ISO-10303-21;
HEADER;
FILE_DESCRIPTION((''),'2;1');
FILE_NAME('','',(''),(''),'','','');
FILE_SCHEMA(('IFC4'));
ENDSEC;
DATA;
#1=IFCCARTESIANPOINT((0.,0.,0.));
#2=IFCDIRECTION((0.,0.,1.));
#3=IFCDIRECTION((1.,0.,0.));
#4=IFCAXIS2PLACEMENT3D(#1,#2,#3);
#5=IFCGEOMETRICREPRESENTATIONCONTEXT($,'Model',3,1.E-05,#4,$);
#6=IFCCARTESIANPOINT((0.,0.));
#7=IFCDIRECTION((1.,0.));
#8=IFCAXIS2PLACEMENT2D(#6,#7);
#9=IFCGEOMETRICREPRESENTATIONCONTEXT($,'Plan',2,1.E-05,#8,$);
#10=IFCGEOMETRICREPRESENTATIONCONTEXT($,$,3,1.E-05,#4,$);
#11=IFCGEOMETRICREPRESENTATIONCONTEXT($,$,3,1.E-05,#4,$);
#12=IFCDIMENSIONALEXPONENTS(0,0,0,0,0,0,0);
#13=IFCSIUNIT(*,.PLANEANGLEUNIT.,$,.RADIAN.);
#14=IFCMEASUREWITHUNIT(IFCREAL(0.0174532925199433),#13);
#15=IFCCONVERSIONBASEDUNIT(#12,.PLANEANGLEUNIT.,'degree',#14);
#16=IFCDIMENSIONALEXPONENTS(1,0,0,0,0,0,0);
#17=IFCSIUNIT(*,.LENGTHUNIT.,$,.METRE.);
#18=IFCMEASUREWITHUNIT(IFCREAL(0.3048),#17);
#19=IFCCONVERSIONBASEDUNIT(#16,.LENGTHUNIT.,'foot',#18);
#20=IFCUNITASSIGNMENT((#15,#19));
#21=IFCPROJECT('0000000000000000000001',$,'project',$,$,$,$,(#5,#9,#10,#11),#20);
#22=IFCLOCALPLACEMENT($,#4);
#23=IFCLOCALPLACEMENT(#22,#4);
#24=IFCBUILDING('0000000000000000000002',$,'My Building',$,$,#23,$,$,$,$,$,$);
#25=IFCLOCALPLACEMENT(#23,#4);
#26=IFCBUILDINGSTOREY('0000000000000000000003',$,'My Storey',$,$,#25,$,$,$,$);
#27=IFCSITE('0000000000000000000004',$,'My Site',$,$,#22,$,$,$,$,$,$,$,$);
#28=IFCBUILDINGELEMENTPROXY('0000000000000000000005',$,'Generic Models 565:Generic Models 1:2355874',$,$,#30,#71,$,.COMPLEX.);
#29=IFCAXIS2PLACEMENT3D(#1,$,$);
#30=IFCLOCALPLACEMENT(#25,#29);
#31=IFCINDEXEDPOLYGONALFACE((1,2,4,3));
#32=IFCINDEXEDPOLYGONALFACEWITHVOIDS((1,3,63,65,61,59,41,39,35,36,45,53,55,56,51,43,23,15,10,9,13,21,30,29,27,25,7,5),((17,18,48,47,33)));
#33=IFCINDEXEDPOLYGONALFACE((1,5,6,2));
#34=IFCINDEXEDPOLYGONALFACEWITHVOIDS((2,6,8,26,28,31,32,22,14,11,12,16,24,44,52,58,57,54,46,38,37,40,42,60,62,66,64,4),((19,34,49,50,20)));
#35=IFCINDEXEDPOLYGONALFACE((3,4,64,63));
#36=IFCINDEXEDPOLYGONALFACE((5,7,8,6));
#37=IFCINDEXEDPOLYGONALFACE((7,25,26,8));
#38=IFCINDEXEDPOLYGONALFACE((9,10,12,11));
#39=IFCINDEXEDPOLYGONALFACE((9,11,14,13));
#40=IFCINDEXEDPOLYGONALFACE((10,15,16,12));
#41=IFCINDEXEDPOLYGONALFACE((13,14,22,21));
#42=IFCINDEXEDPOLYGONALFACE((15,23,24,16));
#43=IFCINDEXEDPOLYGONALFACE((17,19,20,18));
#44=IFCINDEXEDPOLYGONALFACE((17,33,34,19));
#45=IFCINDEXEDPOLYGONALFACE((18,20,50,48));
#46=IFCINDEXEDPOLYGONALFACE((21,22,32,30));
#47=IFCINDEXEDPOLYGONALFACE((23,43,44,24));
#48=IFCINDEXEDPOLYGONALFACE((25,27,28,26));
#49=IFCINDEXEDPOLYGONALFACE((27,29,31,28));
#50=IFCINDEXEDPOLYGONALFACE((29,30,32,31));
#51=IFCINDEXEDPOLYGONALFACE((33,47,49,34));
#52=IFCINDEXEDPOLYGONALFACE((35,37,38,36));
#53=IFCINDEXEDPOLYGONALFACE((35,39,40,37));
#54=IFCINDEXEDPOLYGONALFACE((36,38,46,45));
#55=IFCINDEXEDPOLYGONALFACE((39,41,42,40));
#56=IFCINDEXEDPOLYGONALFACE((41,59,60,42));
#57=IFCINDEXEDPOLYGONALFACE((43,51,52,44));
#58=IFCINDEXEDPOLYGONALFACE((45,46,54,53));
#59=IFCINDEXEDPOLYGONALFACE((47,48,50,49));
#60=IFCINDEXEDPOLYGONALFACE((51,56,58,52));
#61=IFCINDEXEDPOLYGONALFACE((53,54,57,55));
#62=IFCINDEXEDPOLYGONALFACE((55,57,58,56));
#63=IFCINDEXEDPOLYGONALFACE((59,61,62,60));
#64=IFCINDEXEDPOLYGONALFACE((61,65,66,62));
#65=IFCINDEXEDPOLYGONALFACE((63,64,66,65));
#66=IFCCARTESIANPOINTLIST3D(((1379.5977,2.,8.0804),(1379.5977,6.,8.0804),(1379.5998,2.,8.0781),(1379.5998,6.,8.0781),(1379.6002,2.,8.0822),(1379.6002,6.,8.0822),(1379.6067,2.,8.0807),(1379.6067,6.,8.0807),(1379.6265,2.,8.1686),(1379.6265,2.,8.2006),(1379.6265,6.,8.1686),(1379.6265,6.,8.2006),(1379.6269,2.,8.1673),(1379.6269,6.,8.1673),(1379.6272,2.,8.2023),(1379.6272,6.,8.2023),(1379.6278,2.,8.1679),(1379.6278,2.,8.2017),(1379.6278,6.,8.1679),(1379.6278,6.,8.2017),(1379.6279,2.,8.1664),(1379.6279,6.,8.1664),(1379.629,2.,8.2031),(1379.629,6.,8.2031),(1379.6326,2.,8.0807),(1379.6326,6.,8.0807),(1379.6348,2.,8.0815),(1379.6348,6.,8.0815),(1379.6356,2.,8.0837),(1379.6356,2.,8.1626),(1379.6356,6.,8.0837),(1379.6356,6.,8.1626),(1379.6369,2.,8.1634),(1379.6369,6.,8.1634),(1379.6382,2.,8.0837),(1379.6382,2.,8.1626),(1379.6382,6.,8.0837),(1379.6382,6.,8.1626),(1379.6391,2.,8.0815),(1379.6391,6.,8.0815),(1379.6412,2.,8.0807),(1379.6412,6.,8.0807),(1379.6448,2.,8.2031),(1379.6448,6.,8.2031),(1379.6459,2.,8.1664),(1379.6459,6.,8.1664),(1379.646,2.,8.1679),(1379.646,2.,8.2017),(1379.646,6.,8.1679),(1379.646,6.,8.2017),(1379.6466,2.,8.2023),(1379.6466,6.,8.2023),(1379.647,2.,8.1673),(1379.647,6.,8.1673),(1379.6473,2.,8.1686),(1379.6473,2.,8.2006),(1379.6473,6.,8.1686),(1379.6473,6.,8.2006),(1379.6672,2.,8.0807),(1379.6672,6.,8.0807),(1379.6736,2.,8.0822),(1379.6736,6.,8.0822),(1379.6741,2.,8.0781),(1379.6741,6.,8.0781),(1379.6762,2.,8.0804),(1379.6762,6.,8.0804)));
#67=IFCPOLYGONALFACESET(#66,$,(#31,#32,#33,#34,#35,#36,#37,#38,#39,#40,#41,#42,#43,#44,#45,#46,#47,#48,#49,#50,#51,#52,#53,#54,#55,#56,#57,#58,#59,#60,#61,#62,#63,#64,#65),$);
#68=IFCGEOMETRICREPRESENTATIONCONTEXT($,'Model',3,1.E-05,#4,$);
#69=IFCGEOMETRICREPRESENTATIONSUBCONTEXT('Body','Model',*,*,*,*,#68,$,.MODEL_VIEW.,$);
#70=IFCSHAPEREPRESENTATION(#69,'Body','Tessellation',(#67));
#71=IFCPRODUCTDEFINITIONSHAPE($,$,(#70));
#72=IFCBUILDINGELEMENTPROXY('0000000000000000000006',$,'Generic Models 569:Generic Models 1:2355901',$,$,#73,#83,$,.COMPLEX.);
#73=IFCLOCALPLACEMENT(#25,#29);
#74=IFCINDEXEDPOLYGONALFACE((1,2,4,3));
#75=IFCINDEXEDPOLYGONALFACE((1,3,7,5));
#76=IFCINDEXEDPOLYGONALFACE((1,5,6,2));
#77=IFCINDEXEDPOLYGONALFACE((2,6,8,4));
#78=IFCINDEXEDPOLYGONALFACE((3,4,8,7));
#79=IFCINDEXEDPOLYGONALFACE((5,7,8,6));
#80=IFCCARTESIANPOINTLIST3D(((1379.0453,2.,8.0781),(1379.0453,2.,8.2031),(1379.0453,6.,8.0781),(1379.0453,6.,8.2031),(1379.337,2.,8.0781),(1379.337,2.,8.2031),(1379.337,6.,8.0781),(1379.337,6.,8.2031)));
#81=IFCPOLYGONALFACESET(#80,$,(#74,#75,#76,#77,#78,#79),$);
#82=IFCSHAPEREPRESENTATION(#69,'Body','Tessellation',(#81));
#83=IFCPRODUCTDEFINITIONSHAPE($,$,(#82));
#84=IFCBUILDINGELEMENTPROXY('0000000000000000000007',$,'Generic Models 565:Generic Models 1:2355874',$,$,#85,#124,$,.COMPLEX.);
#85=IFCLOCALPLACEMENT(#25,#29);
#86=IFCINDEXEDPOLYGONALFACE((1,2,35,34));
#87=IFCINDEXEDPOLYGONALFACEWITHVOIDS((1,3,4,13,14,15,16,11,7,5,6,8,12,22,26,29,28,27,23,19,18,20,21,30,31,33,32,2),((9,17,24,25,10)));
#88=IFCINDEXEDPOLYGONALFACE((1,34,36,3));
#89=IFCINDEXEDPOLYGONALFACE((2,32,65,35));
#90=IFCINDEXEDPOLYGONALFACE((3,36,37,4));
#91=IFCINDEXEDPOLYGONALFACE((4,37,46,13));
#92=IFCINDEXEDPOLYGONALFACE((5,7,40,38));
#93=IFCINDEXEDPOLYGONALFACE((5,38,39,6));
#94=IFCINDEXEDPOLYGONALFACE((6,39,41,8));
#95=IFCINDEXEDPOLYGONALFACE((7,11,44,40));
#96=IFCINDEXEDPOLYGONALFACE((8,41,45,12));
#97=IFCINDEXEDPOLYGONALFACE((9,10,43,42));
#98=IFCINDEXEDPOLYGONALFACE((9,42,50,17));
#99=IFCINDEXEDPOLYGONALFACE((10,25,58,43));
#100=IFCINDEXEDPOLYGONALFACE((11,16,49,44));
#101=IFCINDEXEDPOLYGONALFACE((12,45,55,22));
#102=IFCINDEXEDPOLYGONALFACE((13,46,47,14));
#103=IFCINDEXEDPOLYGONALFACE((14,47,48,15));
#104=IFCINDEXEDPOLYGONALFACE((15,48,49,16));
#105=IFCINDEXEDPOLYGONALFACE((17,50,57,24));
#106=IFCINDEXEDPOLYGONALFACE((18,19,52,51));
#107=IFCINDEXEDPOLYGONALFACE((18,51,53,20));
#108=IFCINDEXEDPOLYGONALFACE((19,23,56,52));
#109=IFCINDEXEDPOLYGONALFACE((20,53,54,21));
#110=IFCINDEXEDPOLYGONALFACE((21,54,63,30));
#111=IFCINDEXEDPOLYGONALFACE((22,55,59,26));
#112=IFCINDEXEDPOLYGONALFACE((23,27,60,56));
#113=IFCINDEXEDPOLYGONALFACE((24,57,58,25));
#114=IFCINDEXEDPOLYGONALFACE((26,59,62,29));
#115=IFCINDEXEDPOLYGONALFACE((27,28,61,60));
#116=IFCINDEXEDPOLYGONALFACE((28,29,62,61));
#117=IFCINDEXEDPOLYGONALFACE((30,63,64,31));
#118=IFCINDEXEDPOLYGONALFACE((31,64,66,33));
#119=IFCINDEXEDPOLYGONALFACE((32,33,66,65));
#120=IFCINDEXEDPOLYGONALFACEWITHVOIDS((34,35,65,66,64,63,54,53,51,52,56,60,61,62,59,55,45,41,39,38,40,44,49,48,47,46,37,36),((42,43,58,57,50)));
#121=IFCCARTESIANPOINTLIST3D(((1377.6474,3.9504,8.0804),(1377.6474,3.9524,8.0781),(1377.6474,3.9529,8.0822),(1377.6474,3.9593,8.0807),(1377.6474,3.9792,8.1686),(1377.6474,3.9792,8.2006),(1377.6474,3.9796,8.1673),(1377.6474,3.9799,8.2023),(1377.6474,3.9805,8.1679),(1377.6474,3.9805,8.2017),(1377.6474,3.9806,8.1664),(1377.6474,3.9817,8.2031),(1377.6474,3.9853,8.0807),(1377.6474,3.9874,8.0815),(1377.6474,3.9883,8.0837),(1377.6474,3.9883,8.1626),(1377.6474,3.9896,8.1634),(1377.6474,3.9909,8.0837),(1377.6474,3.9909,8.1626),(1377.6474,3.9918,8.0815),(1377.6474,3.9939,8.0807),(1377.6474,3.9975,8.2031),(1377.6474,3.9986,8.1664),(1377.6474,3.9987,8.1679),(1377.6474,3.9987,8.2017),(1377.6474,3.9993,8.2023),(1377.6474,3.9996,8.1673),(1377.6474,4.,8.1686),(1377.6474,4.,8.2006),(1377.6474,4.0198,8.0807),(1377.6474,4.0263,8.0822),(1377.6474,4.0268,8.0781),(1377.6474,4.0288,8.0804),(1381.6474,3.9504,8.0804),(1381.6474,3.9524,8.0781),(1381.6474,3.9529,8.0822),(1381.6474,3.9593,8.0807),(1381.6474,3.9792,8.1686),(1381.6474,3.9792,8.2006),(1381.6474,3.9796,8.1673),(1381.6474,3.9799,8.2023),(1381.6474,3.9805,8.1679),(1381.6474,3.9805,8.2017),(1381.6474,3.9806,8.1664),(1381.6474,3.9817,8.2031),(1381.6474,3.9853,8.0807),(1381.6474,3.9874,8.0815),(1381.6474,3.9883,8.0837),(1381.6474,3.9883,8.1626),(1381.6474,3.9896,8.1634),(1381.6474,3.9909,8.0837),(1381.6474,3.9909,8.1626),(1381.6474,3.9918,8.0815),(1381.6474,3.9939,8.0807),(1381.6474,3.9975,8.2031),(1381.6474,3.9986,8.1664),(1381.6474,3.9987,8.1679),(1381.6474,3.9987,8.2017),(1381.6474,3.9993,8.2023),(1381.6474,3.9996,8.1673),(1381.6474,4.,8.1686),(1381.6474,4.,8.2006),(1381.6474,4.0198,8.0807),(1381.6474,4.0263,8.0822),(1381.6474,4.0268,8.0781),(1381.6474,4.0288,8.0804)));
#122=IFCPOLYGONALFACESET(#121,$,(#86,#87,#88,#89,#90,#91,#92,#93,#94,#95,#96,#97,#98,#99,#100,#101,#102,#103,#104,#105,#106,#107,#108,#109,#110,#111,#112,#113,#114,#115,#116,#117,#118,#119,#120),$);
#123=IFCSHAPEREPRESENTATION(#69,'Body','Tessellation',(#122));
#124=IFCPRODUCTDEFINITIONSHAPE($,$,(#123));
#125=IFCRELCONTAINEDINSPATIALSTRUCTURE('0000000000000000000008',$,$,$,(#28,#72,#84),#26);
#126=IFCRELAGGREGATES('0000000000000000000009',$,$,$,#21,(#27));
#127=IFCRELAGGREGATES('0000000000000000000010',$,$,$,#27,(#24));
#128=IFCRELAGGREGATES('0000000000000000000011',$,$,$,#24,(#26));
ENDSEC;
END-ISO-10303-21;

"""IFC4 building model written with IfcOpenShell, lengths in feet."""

from ifc_helpers import new_model, entity, si_unit, converted_unit, frame, origin_with_axes, origin_2d_with_axis, place, context, subcontext, project, spatial, polyline, line, indexed_curve, outline, extrude, element, save


model = new_model("IFC4")

# Units and contexts
model_context_1 = context("Model", 3, precision=1e-05, world=origin_with_axes())
plan_context = context("Plan", 2, precision=1e-05, world=origin_2d_with_axis())
model_context_2 = context("Model", 3, precision=1e-05, world=origin_with_axes())
context_of_model_1 = context(None, 3, precision=1e-05, world=origin_with_axes())
context_of_model_2 = context(None, 3, precision=1e-05, world=origin_with_axes())
body_context = subcontext(model_context_2, "Body", "Model", "MODEL_VIEW")
ifc_project = project(units=[converted_unit("PLANEANGLEUNIT", "degree", entity("IfcReal", 0.0174532925199433), si_unit("PLANEANGLEUNIT", "RADIAN"), dimensions=[0, 0, 0, 0, 0, 0, 0]), converted_unit("LENGTHUNIT", "foot", entity("IfcReal", 0.3048), si_unit("LENGTHUNIT", "METRE"), dimensions=[1, 0, 0, 0, 0, 0, 0])], contexts=[model_context_1, plan_context, context_of_model_1, context_of_model_2])

# Site, building, storey
site_placement = place(None, origin_with_axes())
site = spatial("IfcSite", under=ifc_project, at=site_placement, Name="My Site")
building_placement = place(site_placement, origin_with_axes())
building = spatial("IfcBuilding", under=site, at=building_placement, Name="My Building")
storey_placement = place(building_placement, origin_with_axes())
storey = spatial("IfcBuildingStorey", under=building, at=storey_placement, Name="My Storey")

# Building element proxies
proxy_1_placement = place(storey_placement, frame((1379.5977, 6.0, 8.0781), z_axis=(0.0, -1.0, 0.0), x_axis=(0.0, 0.0, 1.0)))
element("IfcBuildingElementProxy", 1, at=proxy_1_placement, inside=storey, Name="Generic Models 565:Generic Models 1:2355874", PredefinedType="COMPLEX", context=body_context, shape_type="SweptSolid", body=[
    extrude(outline(indexed_curve([(0.0297, 0.0058), (0.0311, 0.006), (0.0627, 0.0015), (0.0643, 0.0005), (0.0648, -0.0014), (0.0625, -0.017), (0.0615, -0.0187), (0.0597, -0.0192), (0.0281, -0.0146), (0.0268, -0.014), (0.0261, -0.0129), (0.0234, -0.0047), (-0.0547, 0.0066), (-0.0569, 0.006), (-0.0581, 0.0041), (-0.0618, -0.0216), (-0.0612, -0.0282), (-0.0634, -0.0305), (-0.0654, -0.0281), (-0.0547, 0.0455), (-0.0522, 0.0472), (-0.0507, 0.0444), (-0.0532, 0.0382), (-0.0569, 0.0126), (-0.0563, 0.0103), (-0.0543, 0.0092), (0.0238, -0.0021), (0.0286, 0.005), (0.0301, 0.0048), (0.0637, 0.0), (0.0611, -0.018), (0.0275, -0.0132), (0.0244, -0.0035)], segments=[line(7, 6), line(6, 5), line(5, 4), line(4, 3), line(3, 2), line(2, 1), line(1, 28), line(28, 27), line(27, 26), line(26, 25), line(25, 24), line(24, 23), line(23, 22), line(22, 21), line(21, 20), line(20, 19), line(19, 18), line(18, 17), line(17, 16), line(16, 15), line(15, 14), line(14, 13), line(13, 12), line(12, 11), line(11, 10), line(10, 9), line(9, 8), line(8, 7)], self_intersect=False), holes=[indexed_curve([(0.0297, 0.0058), (0.0311, 0.006), (0.0627, 0.0015), (0.0643, 0.0005), (0.0648, -0.0014), (0.0625, -0.017), (0.0615, -0.0187), (0.0597, -0.0192), (0.0281, -0.0146), (0.0268, -0.014), (0.0261, -0.0129), (0.0234, -0.0047), (-0.0547, 0.0066), (-0.0569, 0.006), (-0.0581, 0.0041), (-0.0618, -0.0216), (-0.0612, -0.0282), (-0.0634, -0.0305), (-0.0654, -0.0281), (-0.0547, 0.0455), (-0.0522, 0.0472), (-0.0507, 0.0444), (-0.0532, 0.0382), (-0.0569, 0.0126), (-0.0563, 0.0103), (-0.0543, 0.0092), (0.0238, -0.0021), (0.0286, 0.005), (0.0301, 0.0048), (0.0637, 0.0), (0.0611, -0.018), (0.0275, -0.0132), (0.0244, -0.0035)], segments=[line(31, 32), line(32, 33), line(33, 29), line(29, 30), line(30, 31)], self_intersect=False)]), frame((0.0607, -0.0392, 0.0), z_axis=(0.0, 0.0, -1.0), x_axis=(0.989698, -0.14317, 0.0)), (0.0, 0.0, -1.0), 4.0),
])
proxy_2_placement = place(storey_placement, frame((1379.0453, 6.0, 8.0781), z_axis=(0.0, -1.0, 0.0), x_axis=(0.0, 0.0, 1.0)))
element("IfcBuildingElementProxy", 2, at=proxy_2_placement, inside=storey, Name="Generic Models 569:Generic Models 1:2355901", PredefinedType="COMPLEX", context=body_context, shape_type="SweptSolid", body=[
    extrude(outline(polyline([(-0.1458, -0.0625), (0.1458, -0.0625), (0.1458, 0.0625), (-0.1458, 0.0625), (-0.1458, -0.0625)])), frame((0.0625, -0.1458, 0.0), z_axis=(0.0, 0.0, -1.0), x_axis=(0.0, 1.0, 0.0)), (0.0, 0.0, -1.0), 4.0),
])
proxy_3_placement = place(storey_placement, frame((1377.6474, 3.9503, 8.0781), z_axis=(1.0, 0.0, 0.0), x_axis=(0.0, 0.0, 1.0)))
element("IfcBuildingElementProxy", 3, at=proxy_3_placement, inside=storey, Name="Generic Models 565:Generic Models 1:2355874", PredefinedType="COMPLEX", context=body_context, shape_type="SweptSolid", body=[
    extrude(outline(indexed_curve([(0.0297, 0.0058), (0.0311, 0.006), (0.0627, 0.0015), (0.0643, 0.0005), (0.0648, -0.0014), (0.0625, -0.017), (0.0615, -0.0187), (0.0597, -0.0192), (0.0281, -0.0146), (0.0268, -0.014), (0.0261, -0.0129), (0.0234, -0.0047), (-0.0547, 0.0066), (-0.0569, 0.006), (-0.0581, 0.0041), (-0.0618, -0.0216), (-0.0612, -0.0282), (-0.0634, -0.0305), (-0.0654, -0.0281), (-0.0547, 0.0455), (-0.0522, 0.0472), (-0.0507, 0.0444), (-0.0532, 0.0382), (-0.0569, 0.0126), (-0.0563, 0.0103), (-0.0543, 0.0092), (0.0238, -0.0021), (0.0286, 0.005), (0.0301, 0.0048), (0.0637, 0.0), (0.0611, -0.018), (0.0275, -0.0132), (0.0244, -0.0035)], segments=[line(7, 6), line(6, 5), line(5, 4), line(4, 3), line(3, 2), line(2, 1), line(1, 28), line(28, 27), line(27, 26), line(26, 25), line(25, 24), line(24, 23), line(23, 22), line(22, 21), line(21, 20), line(20, 19), line(19, 18), line(18, 17), line(17, 16), line(16, 15), line(15, 14), line(14, 13), line(13, 12), line(12, 11), line(11, 10), line(10, 9), line(9, 8), line(8, 7)], self_intersect=False), holes=[indexed_curve([(0.0297, 0.0058), (0.0311, 0.006), (0.0627, 0.0015), (0.0643, 0.0005), (0.0648, -0.0014), (0.0625, -0.017), (0.0615, -0.0187), (0.0597, -0.0192), (0.0281, -0.0146), (0.0268, -0.014), (0.0261, -0.0129), (0.0234, -0.0047), (-0.0547, 0.0066), (-0.0569, 0.006), (-0.0581, 0.0041), (-0.0618, -0.0216), (-0.0612, -0.0282), (-0.0634, -0.0305), (-0.0654, -0.0281), (-0.0547, 0.0455), (-0.0522, 0.0472), (-0.0507, 0.0444), (-0.0532, 0.0382), (-0.0569, 0.0126), (-0.0563, 0.0103), (-0.0543, 0.0092), (0.0238, -0.0021), (0.0286, 0.005), (0.0301, 0.0048), (0.0637, 0.0), (0.0611, -0.018), (0.0275, -0.0132), (0.0244, -0.0035)], segments=[line(31, 32), line(32, 33), line(33, 29), line(29, 30), line(30, 31)], self_intersect=False)]), frame((0.0607, -0.0392, 0.0), z_axis=(0.0, 0.0, -1.0), x_axis=(0.989698, -0.14317, 0.0)), (0.0, 0.0, -1.0), 4.0),
])

save(model, "model.ifc")
